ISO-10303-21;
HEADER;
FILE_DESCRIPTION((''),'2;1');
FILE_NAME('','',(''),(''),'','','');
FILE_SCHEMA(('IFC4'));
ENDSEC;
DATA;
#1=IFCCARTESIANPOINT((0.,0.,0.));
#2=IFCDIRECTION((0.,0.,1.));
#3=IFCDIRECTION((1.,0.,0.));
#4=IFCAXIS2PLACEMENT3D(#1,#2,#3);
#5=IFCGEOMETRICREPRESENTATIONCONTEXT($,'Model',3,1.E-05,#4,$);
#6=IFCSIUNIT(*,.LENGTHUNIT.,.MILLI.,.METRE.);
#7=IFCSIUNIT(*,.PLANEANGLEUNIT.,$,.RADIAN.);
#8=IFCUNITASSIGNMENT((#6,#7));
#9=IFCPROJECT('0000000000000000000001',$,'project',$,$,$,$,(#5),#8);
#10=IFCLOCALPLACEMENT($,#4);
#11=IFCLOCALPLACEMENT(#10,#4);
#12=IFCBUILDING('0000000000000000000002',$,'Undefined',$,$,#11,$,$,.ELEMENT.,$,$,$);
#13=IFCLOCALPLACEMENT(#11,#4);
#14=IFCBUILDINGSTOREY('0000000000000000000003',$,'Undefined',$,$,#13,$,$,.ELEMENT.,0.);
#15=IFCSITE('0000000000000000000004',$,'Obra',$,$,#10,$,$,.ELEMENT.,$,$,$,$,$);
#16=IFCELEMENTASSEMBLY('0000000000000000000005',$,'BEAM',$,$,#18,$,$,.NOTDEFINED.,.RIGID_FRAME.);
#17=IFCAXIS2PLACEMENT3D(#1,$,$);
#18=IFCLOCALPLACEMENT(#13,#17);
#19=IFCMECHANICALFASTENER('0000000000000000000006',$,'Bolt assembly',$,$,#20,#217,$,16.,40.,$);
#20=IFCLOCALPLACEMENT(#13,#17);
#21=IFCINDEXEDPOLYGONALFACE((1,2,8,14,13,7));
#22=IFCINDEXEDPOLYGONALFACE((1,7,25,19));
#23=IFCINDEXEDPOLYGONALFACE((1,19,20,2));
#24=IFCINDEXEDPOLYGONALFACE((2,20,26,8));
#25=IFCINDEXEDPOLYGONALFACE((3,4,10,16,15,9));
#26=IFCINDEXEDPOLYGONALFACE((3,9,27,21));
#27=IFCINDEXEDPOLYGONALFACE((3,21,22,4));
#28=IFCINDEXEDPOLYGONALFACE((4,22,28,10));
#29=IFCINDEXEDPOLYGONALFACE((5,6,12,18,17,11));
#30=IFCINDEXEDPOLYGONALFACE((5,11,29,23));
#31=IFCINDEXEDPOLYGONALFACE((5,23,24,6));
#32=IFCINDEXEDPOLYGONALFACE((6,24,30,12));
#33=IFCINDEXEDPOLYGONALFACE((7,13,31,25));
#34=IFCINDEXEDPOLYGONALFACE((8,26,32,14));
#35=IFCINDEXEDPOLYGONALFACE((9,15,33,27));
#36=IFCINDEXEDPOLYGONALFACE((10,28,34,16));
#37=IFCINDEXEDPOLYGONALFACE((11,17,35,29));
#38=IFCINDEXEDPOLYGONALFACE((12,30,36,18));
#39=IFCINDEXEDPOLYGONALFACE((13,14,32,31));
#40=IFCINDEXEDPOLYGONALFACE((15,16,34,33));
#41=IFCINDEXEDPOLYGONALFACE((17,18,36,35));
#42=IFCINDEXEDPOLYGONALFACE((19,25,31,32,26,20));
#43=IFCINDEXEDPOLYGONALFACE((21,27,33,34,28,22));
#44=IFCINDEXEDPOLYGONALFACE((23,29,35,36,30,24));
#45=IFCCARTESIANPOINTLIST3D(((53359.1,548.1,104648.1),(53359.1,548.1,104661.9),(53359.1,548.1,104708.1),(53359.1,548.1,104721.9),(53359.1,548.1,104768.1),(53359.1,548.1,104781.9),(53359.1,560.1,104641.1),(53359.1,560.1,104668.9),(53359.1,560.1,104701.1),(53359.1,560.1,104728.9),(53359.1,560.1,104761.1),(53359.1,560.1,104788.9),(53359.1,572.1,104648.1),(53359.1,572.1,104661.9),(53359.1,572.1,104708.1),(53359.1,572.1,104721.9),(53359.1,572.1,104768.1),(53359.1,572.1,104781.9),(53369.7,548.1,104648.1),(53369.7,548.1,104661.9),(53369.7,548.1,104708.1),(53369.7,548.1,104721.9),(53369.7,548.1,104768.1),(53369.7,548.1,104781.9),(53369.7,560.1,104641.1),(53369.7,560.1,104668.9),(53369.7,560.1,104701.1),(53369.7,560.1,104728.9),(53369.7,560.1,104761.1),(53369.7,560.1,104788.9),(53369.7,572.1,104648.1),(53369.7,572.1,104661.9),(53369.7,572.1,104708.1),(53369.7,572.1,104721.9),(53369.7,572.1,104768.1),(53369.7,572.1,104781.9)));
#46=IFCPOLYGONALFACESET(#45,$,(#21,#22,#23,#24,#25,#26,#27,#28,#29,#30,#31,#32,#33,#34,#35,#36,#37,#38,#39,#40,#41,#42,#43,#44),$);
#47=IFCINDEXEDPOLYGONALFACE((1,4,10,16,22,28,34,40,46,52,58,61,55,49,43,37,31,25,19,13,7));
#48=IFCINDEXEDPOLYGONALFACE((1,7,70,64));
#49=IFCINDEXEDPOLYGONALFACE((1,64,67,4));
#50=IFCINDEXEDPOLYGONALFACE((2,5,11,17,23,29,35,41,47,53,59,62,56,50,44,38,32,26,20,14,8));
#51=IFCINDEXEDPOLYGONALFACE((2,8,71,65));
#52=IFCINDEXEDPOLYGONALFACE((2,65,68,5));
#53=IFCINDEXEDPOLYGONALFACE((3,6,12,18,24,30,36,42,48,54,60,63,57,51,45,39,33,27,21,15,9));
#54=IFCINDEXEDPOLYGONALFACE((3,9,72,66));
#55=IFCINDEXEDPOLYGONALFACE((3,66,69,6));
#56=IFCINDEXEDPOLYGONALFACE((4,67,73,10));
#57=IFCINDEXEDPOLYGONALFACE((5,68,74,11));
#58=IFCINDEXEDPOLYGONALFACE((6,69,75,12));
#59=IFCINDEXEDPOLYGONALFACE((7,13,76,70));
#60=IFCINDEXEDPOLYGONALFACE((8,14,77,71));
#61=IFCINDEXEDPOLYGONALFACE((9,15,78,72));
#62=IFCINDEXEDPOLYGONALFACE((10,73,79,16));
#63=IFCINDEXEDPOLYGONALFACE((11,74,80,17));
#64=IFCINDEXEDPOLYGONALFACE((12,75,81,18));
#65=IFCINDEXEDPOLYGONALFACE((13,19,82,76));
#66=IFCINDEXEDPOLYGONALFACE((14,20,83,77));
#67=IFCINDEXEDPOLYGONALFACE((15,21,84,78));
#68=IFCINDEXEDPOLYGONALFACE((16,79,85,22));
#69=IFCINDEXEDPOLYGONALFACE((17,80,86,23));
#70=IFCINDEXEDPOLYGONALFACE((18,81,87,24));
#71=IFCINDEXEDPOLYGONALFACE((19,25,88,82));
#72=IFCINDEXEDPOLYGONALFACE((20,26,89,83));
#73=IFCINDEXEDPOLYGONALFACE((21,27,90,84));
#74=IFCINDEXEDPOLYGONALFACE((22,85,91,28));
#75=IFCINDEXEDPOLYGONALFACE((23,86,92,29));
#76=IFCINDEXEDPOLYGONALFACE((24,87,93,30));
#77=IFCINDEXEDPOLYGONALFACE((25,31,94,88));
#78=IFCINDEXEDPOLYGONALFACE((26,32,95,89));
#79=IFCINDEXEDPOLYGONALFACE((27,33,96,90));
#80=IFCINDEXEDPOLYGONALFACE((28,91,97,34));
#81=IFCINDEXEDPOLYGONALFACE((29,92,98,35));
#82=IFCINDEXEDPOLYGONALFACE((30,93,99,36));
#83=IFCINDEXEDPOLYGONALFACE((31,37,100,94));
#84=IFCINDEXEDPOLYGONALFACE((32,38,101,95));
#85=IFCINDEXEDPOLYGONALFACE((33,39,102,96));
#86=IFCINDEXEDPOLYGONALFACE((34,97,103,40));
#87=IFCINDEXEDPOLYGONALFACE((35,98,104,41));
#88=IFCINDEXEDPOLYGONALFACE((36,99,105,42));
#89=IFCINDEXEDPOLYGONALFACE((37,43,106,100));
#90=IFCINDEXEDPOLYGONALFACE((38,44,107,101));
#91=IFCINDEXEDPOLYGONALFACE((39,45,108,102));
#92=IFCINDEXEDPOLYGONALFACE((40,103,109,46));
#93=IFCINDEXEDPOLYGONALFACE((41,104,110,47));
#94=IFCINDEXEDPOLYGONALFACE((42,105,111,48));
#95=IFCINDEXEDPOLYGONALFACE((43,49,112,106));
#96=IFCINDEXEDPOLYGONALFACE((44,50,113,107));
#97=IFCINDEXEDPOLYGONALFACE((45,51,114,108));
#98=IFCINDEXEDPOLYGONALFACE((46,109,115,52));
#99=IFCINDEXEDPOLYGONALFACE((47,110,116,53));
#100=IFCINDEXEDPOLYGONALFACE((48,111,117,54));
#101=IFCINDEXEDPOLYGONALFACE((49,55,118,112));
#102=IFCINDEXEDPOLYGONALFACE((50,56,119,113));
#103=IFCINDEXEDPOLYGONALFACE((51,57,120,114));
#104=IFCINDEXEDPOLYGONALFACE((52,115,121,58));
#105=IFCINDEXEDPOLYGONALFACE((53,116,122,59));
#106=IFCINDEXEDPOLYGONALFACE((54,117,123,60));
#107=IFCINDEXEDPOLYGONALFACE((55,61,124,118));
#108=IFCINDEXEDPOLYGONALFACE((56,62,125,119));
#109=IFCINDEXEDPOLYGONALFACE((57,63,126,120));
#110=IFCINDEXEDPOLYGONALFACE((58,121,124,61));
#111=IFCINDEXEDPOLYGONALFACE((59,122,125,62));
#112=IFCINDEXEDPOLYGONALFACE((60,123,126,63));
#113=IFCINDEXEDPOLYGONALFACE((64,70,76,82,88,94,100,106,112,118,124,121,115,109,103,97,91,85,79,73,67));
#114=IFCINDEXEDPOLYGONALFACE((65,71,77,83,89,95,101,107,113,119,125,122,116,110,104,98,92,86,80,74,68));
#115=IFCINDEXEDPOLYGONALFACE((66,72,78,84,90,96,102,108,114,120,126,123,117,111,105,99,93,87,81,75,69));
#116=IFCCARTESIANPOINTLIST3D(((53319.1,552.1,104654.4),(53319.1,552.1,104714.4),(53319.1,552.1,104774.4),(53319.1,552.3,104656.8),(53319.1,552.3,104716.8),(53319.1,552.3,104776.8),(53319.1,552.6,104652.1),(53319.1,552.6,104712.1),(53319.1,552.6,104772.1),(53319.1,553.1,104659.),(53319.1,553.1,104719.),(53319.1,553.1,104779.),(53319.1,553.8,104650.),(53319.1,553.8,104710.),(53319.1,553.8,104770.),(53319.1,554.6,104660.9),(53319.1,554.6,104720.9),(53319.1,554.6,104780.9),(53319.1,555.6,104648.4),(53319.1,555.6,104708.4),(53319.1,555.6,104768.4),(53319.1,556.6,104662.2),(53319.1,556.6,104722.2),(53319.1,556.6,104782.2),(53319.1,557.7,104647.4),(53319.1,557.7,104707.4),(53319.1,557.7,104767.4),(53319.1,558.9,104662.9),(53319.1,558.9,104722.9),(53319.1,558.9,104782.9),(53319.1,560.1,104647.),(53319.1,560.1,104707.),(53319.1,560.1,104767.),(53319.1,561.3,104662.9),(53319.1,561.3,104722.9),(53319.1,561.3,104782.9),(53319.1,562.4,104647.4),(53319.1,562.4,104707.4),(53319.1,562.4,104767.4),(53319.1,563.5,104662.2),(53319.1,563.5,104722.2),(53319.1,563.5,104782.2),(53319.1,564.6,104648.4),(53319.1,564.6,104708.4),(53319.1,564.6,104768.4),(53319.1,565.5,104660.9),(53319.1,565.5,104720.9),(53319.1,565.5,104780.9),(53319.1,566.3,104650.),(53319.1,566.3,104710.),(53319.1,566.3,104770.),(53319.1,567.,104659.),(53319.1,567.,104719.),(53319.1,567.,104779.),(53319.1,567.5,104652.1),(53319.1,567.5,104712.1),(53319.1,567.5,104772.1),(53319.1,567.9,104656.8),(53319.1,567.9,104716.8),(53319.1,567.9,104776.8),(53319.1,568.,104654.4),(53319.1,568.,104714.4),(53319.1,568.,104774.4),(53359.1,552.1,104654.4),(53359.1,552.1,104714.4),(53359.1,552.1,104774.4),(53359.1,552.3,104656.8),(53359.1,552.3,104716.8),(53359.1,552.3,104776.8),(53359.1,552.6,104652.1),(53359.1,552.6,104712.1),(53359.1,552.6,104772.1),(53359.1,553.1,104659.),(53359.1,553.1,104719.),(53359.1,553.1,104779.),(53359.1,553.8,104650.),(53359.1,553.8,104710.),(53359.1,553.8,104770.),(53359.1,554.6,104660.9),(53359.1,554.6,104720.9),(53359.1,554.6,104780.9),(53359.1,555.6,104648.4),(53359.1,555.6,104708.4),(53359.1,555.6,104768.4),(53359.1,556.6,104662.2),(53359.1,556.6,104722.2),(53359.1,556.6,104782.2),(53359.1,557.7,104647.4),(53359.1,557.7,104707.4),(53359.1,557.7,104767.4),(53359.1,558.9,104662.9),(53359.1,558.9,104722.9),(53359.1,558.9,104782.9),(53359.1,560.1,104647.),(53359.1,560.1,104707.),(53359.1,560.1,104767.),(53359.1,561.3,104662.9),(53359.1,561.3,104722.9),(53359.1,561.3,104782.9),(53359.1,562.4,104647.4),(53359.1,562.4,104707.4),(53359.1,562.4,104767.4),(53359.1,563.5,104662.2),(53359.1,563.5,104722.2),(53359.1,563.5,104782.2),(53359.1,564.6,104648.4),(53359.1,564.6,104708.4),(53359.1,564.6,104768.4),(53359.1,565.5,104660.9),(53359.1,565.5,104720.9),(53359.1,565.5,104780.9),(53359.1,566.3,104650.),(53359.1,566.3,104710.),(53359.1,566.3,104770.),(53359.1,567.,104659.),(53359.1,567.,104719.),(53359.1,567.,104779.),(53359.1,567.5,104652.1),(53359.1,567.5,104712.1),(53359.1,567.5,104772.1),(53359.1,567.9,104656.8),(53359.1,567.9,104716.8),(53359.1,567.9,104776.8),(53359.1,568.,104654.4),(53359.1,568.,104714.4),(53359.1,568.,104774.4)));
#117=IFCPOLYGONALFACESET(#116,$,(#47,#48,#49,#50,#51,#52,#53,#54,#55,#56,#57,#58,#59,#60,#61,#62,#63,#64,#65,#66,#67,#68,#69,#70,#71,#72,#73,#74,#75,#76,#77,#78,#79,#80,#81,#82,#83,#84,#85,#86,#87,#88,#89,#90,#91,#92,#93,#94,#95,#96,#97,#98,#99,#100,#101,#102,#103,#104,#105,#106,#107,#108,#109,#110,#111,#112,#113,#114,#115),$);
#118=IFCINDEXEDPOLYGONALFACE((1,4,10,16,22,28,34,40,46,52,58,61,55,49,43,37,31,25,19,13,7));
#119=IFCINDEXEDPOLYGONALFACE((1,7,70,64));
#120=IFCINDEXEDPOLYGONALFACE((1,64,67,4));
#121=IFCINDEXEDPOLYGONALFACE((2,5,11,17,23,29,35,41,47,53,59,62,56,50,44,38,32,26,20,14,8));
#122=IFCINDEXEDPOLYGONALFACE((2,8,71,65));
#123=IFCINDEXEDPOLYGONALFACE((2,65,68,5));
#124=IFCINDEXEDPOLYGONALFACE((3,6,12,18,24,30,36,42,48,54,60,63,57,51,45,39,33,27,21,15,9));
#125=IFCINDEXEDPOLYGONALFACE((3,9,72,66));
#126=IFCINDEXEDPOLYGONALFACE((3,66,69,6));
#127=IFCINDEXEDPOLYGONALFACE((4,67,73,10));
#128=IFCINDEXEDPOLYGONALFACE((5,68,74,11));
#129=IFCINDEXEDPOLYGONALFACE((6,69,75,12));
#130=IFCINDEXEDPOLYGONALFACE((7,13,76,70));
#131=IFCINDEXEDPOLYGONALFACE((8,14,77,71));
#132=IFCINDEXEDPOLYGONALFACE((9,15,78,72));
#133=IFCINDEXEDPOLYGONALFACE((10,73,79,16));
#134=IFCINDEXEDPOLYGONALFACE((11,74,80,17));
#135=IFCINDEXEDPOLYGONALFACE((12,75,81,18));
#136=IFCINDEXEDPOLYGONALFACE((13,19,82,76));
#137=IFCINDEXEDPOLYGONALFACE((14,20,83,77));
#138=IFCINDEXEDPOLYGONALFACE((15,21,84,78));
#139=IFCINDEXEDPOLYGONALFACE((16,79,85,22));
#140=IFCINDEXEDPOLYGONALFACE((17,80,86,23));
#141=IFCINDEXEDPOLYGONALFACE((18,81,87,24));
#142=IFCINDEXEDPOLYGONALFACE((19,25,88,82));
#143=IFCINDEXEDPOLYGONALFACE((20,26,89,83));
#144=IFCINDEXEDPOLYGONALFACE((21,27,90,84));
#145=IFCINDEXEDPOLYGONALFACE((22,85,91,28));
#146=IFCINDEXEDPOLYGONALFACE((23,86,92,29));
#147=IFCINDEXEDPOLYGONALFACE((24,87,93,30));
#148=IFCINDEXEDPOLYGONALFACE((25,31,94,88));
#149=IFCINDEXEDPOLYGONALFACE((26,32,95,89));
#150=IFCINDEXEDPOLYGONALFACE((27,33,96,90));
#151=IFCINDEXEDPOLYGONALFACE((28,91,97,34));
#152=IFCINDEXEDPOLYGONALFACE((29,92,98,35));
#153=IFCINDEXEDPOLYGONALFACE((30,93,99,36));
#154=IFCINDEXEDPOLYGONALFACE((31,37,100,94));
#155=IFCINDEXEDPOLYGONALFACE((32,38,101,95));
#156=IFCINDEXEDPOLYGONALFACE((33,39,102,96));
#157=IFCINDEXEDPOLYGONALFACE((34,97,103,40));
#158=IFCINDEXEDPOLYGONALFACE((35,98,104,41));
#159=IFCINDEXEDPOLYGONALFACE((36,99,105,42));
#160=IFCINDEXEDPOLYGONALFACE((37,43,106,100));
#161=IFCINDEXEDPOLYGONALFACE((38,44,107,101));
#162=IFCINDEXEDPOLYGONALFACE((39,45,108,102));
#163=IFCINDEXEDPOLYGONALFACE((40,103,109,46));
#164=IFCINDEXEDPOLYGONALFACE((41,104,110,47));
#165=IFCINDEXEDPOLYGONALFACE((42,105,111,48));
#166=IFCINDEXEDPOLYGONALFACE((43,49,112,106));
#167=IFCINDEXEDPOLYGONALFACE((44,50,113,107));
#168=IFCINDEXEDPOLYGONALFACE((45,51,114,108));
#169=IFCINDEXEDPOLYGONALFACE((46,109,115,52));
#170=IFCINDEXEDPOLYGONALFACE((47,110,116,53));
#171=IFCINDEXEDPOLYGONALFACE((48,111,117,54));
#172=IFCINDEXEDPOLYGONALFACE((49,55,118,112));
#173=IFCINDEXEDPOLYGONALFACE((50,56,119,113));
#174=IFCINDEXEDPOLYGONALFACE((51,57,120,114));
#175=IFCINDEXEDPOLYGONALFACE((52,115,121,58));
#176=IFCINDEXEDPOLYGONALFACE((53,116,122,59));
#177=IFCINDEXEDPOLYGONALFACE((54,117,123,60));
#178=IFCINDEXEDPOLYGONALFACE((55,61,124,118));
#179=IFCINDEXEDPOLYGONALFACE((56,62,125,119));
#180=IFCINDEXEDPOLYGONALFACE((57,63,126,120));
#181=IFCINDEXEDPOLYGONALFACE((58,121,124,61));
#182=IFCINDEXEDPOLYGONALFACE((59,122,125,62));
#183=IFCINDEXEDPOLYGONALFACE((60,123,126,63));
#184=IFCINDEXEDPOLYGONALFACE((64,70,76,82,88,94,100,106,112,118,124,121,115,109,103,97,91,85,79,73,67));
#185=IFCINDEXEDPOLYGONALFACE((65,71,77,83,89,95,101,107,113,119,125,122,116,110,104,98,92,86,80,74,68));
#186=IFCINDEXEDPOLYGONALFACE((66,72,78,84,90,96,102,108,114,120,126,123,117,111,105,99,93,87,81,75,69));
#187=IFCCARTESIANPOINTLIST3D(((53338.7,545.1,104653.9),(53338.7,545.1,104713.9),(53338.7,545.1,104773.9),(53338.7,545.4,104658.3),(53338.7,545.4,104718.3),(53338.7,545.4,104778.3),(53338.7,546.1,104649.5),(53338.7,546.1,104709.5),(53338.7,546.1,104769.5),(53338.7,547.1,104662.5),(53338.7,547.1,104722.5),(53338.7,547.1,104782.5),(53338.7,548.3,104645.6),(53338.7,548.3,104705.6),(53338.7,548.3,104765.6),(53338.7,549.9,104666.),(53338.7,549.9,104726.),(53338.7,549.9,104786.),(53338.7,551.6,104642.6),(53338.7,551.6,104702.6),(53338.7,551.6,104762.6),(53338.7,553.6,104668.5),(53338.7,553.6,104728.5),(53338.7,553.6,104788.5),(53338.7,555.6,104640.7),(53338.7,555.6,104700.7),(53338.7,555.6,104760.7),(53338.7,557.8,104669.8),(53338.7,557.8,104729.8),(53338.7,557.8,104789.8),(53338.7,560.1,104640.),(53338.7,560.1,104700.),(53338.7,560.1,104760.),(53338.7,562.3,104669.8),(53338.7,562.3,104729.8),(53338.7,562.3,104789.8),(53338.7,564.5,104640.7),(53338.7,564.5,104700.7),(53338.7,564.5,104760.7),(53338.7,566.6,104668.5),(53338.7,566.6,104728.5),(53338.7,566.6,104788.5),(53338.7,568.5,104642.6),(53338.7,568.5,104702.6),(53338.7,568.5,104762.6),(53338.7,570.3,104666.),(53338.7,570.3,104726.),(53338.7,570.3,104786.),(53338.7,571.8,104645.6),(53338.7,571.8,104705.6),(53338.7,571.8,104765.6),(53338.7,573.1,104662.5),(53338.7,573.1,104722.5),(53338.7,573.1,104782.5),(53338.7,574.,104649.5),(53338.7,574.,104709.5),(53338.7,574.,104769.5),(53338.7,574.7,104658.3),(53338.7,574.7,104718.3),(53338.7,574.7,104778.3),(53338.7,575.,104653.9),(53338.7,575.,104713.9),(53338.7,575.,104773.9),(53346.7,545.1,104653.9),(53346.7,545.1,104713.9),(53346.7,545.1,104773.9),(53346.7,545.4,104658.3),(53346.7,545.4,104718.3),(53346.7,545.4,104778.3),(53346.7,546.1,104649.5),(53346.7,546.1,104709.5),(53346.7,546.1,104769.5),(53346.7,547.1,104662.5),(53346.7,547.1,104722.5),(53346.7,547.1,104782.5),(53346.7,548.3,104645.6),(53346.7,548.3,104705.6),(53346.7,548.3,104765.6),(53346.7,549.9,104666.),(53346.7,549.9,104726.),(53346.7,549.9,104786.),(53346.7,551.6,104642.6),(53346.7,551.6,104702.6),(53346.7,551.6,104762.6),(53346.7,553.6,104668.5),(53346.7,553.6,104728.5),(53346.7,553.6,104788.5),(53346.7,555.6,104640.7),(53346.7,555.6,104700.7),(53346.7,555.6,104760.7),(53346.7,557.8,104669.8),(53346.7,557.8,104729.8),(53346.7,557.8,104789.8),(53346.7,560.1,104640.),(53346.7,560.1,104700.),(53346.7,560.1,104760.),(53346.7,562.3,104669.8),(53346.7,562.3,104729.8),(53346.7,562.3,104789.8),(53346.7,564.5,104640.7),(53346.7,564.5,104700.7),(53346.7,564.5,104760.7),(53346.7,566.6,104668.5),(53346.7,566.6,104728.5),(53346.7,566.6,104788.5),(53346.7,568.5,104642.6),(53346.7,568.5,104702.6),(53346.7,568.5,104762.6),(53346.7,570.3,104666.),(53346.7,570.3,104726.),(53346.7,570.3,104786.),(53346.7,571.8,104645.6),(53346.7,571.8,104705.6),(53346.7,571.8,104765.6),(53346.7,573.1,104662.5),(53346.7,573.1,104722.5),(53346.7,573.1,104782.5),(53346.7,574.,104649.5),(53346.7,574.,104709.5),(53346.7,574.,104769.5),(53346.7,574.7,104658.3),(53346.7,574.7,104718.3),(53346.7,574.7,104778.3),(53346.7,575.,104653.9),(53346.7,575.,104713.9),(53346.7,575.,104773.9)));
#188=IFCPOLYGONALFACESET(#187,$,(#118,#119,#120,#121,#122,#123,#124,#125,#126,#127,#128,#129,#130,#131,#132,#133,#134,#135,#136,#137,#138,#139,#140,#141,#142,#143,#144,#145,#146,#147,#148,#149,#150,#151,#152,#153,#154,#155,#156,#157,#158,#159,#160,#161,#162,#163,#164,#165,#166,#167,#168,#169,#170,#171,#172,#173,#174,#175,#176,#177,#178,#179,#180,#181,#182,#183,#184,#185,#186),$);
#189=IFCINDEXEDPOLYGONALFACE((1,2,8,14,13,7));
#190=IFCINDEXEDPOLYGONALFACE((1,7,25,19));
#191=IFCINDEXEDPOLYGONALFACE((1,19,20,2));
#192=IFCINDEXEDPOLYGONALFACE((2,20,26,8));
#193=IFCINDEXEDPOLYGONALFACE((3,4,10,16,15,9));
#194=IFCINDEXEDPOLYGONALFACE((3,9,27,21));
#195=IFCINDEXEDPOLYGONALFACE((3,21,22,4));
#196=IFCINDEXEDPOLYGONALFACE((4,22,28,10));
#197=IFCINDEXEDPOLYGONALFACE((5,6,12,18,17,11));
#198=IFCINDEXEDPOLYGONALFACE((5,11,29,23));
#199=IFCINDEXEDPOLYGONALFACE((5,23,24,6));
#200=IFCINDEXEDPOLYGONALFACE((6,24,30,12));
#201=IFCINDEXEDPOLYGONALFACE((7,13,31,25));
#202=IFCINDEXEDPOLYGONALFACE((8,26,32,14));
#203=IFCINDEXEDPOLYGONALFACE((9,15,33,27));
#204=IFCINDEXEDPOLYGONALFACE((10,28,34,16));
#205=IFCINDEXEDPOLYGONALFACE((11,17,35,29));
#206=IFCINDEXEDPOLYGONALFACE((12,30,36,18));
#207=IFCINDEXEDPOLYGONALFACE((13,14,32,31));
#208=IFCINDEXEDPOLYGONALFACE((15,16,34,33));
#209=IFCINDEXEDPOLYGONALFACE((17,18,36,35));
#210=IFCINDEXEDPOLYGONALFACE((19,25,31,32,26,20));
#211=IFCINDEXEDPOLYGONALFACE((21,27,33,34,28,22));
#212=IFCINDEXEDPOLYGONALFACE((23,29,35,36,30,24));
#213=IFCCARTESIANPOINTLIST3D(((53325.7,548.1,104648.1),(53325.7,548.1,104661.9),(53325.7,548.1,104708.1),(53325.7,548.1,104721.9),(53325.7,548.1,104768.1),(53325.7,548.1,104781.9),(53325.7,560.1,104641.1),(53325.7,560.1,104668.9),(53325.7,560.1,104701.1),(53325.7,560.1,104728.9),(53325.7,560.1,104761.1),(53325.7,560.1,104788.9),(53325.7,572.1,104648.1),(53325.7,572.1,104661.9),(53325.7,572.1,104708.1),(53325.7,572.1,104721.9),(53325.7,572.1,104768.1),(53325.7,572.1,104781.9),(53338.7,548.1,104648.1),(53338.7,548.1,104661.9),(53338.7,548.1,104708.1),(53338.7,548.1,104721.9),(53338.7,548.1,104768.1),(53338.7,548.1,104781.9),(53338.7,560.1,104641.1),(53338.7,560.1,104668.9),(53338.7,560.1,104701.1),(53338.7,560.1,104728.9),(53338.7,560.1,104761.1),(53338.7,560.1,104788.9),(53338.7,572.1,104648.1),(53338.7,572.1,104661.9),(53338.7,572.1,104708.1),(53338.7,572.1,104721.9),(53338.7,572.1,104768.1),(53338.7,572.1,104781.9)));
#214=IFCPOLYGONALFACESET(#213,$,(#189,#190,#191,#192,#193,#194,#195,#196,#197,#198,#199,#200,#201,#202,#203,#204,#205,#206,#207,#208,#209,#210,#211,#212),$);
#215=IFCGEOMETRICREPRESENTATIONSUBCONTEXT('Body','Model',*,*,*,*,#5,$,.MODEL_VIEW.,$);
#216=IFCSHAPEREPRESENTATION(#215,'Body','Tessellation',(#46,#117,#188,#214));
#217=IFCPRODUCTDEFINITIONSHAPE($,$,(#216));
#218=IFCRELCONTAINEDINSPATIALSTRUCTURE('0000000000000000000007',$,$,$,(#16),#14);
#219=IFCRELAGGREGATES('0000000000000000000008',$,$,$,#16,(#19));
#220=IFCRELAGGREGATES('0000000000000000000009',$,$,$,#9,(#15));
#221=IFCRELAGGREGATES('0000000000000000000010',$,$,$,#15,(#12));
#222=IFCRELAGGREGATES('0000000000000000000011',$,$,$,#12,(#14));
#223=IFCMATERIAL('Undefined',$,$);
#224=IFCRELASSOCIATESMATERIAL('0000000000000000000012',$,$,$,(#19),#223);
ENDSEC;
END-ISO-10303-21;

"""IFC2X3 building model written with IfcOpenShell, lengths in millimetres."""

from ifc_helpers import new_model, si_unit, frame, origin_with_axes, origin_2d_with_axis, place, context, subcontext, project, spatial, polyline, circle, outline, extrude, source, transform, mapped, material, element, aggregate, save


model = new_model("IFC2X3")

# Units and contexts
model_context = context("Model", 3, precision=1e-05, world=origin_with_axes())
body_context = subcontext(model_context, "Body", "Model", "MODEL_VIEW")
ifc_project = project(units=[si_unit("LENGTHUNIT", "METRE", prefix="MILLI"), si_unit("PLANEANGLEUNIT", "RADIAN")], contexts=[model_context])

# Site, building, storey
site_placement = place(None, origin_with_axes())
site = spatial("IfcSite", under=ifc_project, at=site_placement, Name="Obra", CompositionType="ELEMENT")
building_placement = place(site_placement, origin_with_axes())
building = spatial("IfcBuilding", under=site, at=building_placement, Name="Undefined", CompositionType="ELEMENT")
storey_placement = place(building_placement, origin_with_axes())
storey = spatial("IfcBuildingStorey", under=building, at=storey_placement, Name="Undefined", CompositionType="ELEMENT", Elevation=0.0)

# Element assembly, mechanical fastener
ifc_material_1 = material(Name="Undefined")
shared_shape_1 = source(origin_with_axes(), body_context, "Body", "SweptSolid", [
    extrude(outline(polyline([(13.9, 0.0), (6.9, 12.0), (-6.9, 12.0), (-13.9, 0.0), (-6.9, -12.0), (6.9, -12.0), (13.9, 0.0)])), frame((0.0, -19.7, 0.0), z_axis=(0.0, 1.0, 0.0), x_axis=(1.0, 0.0, 0.0)), (0.0, 0.0, 1.0), 10.6),
    extrude(circle(Radius=8.0, at=origin_2d_with_axis()), frame((0.0, -9.1, 0.0), z_axis=(0.0, 1.0, 0.0), x_axis=(1.0, 0.0, 0.0)), (0.0, 0.0, 1.0), 40.0),
    extrude(circle(Radius=15.0, at=origin_2d_with_axis()), frame((0.0, 3.3, 0.0), z_axis=(0.0, 1.0, 0.0), x_axis=(1.0, 0.0, 0.0)), (0.0, 0.0, 1.0), 8.0),
    extrude(outline(polyline([(13.9, 0.0), (6.9, 12.0), (-6.9, 12.0), (-13.9, 0.0), (-6.9, -12.0), (6.9, -12.0), (13.9, 0.0)])), frame((0.0, 11.3, 0.0), z_axis=(0.0, 1.0, 0.0), x_axis=(1.0, 0.0, 0.0)), (0.0, 0.0, 1.0), 13.0),
])
assembly_1_placement = place(storey_placement, origin_with_axes())
assembly_1 = element("IfcElementAssembly", 1, at=assembly_1_placement, inside=storey, Name="BEAM", AssemblyPlace="NOTDEFINED", PredefinedType="RIGID_FRAME")
mechanical_fastener_1_placement = place(assembly_1_placement, frame((53350.0, 510.1, 104835.0), z_axis=(-0.000002, 1.0, 0.0), x_axis=(0.0, 0.0, -1.0)))
mechanical_fastener_1 = element("IfcMechanicalFastener", 2, at=mechanical_fastener_1_placement, material=ifc_material_1, Name="Bolt assembly", NominalDiameter=16.0, NominalLength=40.0, context=body_context, shape_type="MappedRepresentation", body=[
    mapped(shared_shape_1, transform((60.0, 0.0, 50.0))),
    mapped(shared_shape_1, transform((120.0, 0.0, 50.0))),
    mapped(shared_shape_1, transform((180.0, 0.0, 50.0))),
])

aggregate(assembly_1, [mechanical_fastener_1])

save(model, "model.ifc")
